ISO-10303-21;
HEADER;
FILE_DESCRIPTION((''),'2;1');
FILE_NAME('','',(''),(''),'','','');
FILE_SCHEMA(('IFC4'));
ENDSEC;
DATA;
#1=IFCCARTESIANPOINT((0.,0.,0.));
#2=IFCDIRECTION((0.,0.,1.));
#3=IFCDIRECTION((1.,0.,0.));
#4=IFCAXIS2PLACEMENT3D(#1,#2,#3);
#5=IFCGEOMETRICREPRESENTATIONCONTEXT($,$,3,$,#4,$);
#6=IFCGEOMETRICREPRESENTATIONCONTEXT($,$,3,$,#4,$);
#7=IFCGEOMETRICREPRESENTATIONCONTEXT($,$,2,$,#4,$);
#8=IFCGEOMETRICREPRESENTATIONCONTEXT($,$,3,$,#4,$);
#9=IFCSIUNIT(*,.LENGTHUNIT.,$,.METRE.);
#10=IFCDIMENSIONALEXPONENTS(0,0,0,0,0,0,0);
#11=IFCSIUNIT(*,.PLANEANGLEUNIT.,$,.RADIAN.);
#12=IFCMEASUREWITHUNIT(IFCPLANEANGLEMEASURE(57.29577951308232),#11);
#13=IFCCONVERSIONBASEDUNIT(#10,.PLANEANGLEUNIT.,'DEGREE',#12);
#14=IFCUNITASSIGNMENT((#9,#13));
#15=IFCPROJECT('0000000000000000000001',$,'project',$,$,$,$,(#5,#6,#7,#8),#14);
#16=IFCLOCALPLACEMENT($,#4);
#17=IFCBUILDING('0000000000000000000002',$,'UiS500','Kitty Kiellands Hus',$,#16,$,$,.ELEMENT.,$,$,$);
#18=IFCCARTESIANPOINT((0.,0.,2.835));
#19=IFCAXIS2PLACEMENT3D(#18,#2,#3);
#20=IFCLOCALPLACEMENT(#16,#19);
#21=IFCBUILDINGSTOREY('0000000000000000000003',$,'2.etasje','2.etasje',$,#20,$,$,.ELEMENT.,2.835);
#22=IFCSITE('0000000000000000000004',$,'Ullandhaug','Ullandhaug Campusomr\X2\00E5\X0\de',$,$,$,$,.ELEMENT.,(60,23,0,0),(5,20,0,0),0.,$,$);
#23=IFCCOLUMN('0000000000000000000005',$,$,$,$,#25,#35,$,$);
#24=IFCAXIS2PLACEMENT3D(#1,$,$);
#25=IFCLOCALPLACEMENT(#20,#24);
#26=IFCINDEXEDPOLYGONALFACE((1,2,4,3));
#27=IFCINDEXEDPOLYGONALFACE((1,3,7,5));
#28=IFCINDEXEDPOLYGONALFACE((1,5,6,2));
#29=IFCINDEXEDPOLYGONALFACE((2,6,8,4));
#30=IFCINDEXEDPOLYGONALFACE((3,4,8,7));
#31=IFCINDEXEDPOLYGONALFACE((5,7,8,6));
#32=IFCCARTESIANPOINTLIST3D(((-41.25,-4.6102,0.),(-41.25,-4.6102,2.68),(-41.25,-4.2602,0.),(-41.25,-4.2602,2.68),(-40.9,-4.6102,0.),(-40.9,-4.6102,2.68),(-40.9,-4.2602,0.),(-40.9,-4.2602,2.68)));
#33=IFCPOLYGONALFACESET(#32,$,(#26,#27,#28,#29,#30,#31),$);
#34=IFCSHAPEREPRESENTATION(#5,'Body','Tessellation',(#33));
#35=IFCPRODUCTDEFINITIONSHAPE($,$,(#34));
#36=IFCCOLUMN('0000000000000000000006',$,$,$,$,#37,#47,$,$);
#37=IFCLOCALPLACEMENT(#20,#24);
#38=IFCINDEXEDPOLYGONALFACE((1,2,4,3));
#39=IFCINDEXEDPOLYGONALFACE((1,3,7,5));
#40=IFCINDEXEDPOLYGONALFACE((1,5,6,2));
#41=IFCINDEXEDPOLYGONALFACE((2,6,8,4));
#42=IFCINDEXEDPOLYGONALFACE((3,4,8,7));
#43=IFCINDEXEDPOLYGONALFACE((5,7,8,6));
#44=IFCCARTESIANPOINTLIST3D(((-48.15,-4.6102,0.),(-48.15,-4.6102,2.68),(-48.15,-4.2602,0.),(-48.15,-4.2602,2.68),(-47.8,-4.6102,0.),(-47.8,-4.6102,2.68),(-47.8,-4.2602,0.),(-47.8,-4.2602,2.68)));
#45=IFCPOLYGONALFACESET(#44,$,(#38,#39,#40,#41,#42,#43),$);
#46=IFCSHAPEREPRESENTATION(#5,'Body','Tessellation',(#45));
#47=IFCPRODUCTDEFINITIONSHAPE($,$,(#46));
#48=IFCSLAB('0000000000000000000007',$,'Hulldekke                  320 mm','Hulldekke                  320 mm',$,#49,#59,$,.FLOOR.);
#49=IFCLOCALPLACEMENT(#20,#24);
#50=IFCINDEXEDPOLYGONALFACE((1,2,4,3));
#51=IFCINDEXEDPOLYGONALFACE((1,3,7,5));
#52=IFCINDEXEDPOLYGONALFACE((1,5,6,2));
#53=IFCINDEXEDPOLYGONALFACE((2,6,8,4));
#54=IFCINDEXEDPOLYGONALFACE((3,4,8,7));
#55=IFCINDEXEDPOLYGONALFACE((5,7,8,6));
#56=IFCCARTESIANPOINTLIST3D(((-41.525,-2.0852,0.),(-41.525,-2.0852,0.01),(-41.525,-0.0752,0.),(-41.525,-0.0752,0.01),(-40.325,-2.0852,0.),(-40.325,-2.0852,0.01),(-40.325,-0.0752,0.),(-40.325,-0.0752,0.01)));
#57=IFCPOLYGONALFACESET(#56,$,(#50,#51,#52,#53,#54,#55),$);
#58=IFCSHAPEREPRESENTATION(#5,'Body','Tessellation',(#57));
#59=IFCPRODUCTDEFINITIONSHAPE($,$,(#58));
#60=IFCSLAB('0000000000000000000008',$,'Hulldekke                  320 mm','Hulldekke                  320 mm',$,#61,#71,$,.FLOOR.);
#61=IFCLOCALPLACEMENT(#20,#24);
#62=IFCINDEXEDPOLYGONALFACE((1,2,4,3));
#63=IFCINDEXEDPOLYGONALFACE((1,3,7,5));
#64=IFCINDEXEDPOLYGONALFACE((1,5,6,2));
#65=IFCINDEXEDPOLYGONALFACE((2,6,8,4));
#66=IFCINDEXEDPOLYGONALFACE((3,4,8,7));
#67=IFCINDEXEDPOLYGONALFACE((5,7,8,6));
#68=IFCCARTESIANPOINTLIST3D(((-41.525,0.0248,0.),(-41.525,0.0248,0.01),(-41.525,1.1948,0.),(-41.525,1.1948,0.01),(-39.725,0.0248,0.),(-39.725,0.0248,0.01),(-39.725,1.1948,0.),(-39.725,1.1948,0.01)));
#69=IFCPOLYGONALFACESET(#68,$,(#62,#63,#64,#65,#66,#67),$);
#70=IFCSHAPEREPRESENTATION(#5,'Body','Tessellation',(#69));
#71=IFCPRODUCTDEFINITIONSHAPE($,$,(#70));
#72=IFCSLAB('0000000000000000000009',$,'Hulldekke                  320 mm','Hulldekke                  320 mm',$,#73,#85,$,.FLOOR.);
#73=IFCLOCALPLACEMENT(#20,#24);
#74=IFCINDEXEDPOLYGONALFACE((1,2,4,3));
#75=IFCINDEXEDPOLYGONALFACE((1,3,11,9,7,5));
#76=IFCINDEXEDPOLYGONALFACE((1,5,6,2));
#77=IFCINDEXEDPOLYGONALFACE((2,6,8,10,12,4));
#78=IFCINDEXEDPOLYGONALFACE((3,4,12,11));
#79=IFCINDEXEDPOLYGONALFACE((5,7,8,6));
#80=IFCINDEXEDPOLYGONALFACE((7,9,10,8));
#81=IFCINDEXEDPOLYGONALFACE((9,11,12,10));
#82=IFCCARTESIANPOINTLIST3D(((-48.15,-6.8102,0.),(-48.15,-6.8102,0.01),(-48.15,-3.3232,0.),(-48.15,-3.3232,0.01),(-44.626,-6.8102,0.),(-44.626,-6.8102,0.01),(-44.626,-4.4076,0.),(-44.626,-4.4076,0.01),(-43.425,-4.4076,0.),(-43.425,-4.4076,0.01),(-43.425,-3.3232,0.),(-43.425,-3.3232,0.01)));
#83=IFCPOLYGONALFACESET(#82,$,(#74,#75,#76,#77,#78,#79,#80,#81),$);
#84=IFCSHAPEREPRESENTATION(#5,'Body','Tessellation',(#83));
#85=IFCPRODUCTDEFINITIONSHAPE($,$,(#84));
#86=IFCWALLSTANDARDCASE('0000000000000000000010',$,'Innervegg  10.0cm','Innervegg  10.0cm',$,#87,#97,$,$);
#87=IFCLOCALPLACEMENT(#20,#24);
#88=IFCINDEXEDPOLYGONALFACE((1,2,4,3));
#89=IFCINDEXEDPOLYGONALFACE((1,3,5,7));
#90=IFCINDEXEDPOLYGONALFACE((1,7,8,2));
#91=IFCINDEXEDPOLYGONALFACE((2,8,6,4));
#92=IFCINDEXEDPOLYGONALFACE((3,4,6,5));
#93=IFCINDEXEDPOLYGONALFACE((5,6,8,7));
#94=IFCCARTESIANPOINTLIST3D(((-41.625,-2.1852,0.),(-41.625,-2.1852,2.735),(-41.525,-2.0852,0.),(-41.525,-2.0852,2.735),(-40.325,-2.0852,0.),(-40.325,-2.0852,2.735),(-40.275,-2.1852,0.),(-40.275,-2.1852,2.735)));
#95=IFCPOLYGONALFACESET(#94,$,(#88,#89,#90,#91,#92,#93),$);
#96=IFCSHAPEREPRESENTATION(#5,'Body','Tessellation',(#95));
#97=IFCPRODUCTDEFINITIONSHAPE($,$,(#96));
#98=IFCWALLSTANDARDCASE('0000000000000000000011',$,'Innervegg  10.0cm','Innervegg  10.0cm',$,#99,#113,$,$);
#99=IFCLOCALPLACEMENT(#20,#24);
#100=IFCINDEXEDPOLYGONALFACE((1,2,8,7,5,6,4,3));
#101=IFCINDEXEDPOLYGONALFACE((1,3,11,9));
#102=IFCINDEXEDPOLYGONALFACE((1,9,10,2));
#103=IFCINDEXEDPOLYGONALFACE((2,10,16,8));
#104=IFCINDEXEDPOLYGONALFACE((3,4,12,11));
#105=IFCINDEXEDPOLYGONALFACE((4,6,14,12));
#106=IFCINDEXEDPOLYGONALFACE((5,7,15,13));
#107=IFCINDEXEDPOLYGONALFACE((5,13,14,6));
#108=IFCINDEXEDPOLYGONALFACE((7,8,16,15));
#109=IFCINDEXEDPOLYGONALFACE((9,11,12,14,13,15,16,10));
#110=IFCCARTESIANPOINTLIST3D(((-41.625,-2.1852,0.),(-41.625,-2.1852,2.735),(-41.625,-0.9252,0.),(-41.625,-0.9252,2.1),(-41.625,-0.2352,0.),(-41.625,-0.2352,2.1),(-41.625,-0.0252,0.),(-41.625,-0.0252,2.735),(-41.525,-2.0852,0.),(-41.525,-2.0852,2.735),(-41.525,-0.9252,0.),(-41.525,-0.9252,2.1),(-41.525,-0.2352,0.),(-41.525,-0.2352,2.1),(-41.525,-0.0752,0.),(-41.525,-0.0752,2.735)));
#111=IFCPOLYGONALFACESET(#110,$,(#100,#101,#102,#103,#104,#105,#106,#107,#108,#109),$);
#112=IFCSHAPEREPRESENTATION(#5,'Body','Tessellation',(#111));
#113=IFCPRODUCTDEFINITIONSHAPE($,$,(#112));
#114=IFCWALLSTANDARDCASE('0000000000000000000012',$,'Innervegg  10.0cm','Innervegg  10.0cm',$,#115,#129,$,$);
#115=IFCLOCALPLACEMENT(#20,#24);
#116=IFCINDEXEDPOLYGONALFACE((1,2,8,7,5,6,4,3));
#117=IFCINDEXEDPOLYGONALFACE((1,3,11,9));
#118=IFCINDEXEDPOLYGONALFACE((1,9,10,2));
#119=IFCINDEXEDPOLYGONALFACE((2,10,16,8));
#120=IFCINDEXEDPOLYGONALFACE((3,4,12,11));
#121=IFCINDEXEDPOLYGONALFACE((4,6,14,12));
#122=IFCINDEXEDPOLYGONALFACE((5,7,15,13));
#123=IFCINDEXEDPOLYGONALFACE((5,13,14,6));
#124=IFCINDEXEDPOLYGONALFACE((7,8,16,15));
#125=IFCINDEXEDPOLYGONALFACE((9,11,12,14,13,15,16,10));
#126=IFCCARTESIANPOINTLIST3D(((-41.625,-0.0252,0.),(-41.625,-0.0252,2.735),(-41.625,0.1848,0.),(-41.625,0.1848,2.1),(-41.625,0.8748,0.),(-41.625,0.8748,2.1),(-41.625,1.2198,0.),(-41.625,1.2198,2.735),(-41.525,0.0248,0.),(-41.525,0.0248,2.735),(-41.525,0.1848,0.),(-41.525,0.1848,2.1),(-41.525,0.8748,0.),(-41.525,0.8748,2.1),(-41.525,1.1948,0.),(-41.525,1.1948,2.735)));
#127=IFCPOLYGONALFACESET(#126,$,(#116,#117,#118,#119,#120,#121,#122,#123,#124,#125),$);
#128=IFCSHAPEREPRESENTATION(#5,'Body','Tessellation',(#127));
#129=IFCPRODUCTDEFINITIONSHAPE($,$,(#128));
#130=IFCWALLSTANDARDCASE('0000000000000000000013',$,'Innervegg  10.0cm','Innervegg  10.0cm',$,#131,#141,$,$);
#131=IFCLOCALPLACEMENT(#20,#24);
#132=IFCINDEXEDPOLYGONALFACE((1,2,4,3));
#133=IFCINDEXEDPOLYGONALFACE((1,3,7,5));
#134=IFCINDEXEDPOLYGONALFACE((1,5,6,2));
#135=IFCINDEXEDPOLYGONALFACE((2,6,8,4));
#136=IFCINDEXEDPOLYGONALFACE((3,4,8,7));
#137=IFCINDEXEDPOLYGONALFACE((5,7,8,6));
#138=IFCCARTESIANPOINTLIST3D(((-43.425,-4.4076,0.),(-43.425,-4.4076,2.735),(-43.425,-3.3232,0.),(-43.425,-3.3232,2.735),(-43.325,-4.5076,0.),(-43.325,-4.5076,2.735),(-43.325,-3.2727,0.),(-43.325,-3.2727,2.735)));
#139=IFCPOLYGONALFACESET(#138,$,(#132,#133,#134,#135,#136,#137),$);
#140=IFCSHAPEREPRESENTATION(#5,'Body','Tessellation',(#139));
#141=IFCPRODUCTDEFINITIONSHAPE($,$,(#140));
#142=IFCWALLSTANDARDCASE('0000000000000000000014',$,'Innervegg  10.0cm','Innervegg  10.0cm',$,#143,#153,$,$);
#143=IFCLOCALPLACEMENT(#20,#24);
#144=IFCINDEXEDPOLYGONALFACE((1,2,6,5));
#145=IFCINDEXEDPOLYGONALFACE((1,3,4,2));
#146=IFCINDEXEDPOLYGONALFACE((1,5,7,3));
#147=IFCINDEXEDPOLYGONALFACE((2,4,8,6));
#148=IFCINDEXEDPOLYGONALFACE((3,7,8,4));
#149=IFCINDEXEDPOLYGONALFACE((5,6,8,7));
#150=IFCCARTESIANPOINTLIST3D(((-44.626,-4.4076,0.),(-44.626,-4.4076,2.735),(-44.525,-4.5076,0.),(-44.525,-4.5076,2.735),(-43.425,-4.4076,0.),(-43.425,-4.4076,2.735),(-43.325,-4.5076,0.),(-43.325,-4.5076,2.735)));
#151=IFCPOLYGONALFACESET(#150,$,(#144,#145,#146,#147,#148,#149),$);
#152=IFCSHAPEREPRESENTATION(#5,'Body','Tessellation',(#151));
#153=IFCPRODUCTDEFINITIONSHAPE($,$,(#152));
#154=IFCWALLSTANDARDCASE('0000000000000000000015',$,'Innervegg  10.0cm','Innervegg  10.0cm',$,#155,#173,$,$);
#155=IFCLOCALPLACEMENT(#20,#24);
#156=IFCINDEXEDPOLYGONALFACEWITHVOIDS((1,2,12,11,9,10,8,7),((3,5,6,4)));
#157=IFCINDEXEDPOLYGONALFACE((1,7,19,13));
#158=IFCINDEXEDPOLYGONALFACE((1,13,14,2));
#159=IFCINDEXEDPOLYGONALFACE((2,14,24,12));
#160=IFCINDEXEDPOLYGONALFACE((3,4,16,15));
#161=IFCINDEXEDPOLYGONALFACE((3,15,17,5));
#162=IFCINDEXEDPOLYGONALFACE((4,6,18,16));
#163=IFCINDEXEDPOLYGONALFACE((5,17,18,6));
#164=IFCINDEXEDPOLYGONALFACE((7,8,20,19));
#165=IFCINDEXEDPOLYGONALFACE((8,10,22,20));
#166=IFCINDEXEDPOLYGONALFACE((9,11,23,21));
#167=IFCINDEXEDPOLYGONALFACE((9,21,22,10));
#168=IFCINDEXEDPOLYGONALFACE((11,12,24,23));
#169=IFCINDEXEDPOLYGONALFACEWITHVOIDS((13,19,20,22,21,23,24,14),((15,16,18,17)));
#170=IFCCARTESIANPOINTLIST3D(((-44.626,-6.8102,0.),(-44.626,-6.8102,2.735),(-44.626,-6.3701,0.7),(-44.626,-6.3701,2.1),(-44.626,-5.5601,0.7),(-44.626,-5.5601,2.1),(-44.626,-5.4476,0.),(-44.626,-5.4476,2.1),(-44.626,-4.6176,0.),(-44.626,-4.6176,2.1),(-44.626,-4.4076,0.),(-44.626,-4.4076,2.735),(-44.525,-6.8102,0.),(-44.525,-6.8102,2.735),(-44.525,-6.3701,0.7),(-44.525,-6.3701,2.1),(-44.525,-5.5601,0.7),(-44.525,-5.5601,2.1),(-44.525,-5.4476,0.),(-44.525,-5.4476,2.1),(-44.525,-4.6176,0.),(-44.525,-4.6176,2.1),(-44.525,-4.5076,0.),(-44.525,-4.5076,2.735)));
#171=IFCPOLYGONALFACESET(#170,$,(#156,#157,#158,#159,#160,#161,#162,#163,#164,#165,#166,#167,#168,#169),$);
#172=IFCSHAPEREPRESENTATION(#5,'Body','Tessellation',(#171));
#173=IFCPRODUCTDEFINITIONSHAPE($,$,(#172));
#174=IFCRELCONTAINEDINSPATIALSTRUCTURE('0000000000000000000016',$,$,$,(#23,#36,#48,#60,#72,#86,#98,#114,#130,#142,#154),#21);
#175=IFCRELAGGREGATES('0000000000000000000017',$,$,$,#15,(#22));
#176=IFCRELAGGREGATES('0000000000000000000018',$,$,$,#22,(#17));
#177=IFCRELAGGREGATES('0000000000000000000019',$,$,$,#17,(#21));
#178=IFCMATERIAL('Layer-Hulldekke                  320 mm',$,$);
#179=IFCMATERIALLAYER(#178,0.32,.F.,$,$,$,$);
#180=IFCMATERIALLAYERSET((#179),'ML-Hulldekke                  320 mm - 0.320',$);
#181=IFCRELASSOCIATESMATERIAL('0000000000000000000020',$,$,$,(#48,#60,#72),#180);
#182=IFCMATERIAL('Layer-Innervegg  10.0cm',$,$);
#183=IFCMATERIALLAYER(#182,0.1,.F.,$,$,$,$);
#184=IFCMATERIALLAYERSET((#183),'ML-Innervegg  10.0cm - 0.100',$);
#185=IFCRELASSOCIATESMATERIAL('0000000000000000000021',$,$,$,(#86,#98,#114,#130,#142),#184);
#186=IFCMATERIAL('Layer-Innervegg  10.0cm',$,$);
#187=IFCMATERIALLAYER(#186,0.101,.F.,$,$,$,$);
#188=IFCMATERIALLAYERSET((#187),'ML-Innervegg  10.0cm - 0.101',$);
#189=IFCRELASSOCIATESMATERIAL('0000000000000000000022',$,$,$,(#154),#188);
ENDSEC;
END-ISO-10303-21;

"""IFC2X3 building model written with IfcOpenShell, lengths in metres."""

from ifc_helpers import new_model, entity, si_unit, converted_unit, frame, origin_with_axes, origin_2d_with_axis, place, context, project, spatial, polyline, rectangle, outline, extrude, material, layer, layer_set, layer_usage, element, save


model = new_model("IFC2X3")

# Units and contexts
context_of_model_1 = context(None, 3, world=origin_with_axes())
context_of_model_2 = context(None, 3, world=origin_with_axes())
context_of_model_3 = context(None, 2, world=origin_with_axes())
context_of_model_4 = context(None, 3, world=origin_with_axes())
ifc_project = project(units=[si_unit("LENGTHUNIT", "METRE"), converted_unit("PLANEANGLEUNIT", "DEGREE", entity("IfcPlaneAngleMeasure", 57.29577951308232), si_unit("PLANEANGLEUNIT", "RADIAN"), dimensions=[0, 0, 0, 0, 0, 0, 0])], contexts=[context_of_model_1, context_of_model_2, context_of_model_3, context_of_model_4])

# Site, building, storey
site = spatial("IfcSite", under=ifc_project, Name="Ullandhaug", Description="Ullandhaug Campusområde", CompositionType="ELEMENT", RefLatitude=(60, 23, 0, 0), RefLongitude=(5, 20, 0, 0), RefElevation=0.0)
building_placement = place(None, origin_with_axes())
building = spatial("IfcBuilding", under=site, at=building_placement, Name="UiS500", Description="Kitty Kiellands Hus", CompositionType="ELEMENT")
storey_placement = place(building_placement, frame((0.0, 0.0, 2.835), z_axis=(0.0, 0.0, 1.0), x_axis=(1.0, 0.0, 0.0)))
storey = spatial("IfcBuildingStorey", under=building, at=storey_placement, Name="2.etasje", Description="2.etasje", CompositionType="ELEMENT", Elevation=2.835)

# Columns
for number, where, z_axis, x_axis in (
    (1, (-41.075, -4.4352, 0.0), (0.0, 0.0, 1.0), (1.0, 0.0, 0.0)),
    (2, (-47.975, -4.4352, 0.0), (0.0, 0.0, 1.0), (1.0, 0.0, 0.0)),
):
    element("IfcColumn", number, at=place(storey_placement, frame(where, z_axis=z_axis, x_axis=x_axis)), inside=storey, context=context_of_model_1, shape_type="SweptSolid", body=[
        extrude(rectangle(XDim=0.35, YDim=0.35, at=origin_2d_with_axis()), origin_with_axes(), (0.0, 0.0, 1.0), 2.68),
    ])

# Slabs
ifc_material_1 = material(Name="Layer-Hulldekke                  320 mm")
ifc_layer_1 = layer(ifc_material_1, 0.32, ventilated=False)
ifc_layer_set_1 = layer_set([ifc_layer_1], Name="ML-Hulldekke                  320 mm - 0.320")
ifc_layer_usage_1 = layer_usage(ifc_layer_set_1, "AXIS2", "POSITIVE", 0.0)
slab_1_placement = place(storey_placement, frame((-41.525, -2.0852, 0.0), z_axis=(0.0, 0.0, 1.0), x_axis=(1.0, 0.0, 0.0)))
element("IfcSlab", 3, at=slab_1_placement, inside=storey, material=ifc_layer_usage_1, Name="Hulldekke                  320 mm", Description="Hulldekke                  320 mm", PredefinedType="FLOOR", context=context_of_model_1, shape_type="SweptSolid", body=[
    extrude(outline(polyline([(0.0, 0.0), (1.2, 0.0), (1.2, 2.01), (0.0, 2.01), (0.0, 0.0)])), origin_with_axes(), (0.0, 0.0, 1.0), 0.01),
])
slab_2_placement = place(storey_placement, frame((-41.525, 0.0248, 0.0), z_axis=(0.0, 0.0, 1.0), x_axis=(1.0, 0.0, 0.0)))
element("IfcSlab", 4, at=slab_2_placement, inside=storey, material=ifc_layer_usage_1, Name="Hulldekke                  320 mm", Description="Hulldekke                  320 mm", PredefinedType="FLOOR", context=context_of_model_1, shape_type="SweptSolid", body=[
    extrude(outline(polyline([(0.0, 0.0), (1.8, 0.0), (1.8, 1.17), (0.0, 1.17), (0.0, 0.0)])), origin_with_axes(), (0.0, 0.0, 1.0), 0.01),
])
slab_3_placement = place(storey_placement, frame((-43.425, -3.3232, 0.0), z_axis=(0.0, 0.0, 1.0), x_axis=(1.0, 0.0, 0.0)))
element("IfcSlab", 5, at=slab_3_placement, inside=storey, material=ifc_layer_usage_1, Name="Hulldekke                  320 mm", Description="Hulldekke                  320 mm", PredefinedType="FLOOR", context=context_of_model_1, shape_type="SweptSolid", body=[
    extrude(outline(polyline([(0.0, 0.0), (4.725, 0.0), (4.725, 3.487), (1.201, 3.487), (1.201, 1.0843), (0.0, 1.0843), (0.0, 0.0)])), frame((0.0, 0.0, 0.0), z_axis=(0.0, 0.0, 1.0), x_axis=(-1.0, 0.0, 0.0)), (0.0, 0.0, 1.0), 0.01),
])

# Wall
ifc_material_2 = material(Name="Layer-Innervegg  10.0cm")
ifc_layer_2 = layer(ifc_material_2, 0.1, ventilated=False)
ifc_layer_set_2 = layer_set([ifc_layer_2], Name="ML-Innervegg  10.0cm - 0.100")
ifc_layer_usage_2 = layer_usage(ifc_layer_set_2, "AXIS2", "POSITIVE", 0.0)
wall_1_placement = place(storey_placement, frame((-40.325, -2.0852, 0.0), z_axis=(0.0, 0.0, 1.0), x_axis=(-1.0, 0.0, 0.0)))
element("IfcWallStandardCase", 6, at=wall_1_placement, inside=storey, material=ifc_layer_usage_2, Name="Innervegg  10.0cm", Description="Innervegg  10.0cm", context=context_of_model_1, shape_type="SweptSolid", body=[
    extrude(outline(polyline([(0.0, 0.0), (1.2, 0.0), (1.3, 0.1), (-0.05, 0.1), (0.0, 0.0)])), frame((0.0, 0.0, 0.0), z_axis=(0.0, 0.0, 1.0), x_axis=(1.0, 0.0, 0.0)), (0.0, 0.0, 1.0), 2.735),
])

# Walls, openings
wall_2_placement = place(storey_placement, frame((-41.525, -2.0852, 0.0), z_axis=(0.0, 0.0, 1.0), x_axis=(0.0, 1.0, 0.0)))
wall_2 = element("IfcWallStandardCase", 7, at=wall_2_placement, inside=storey, material=ifc_layer_usage_2, Name="Innervegg  10.0cm", Description="Innervegg  10.0cm", context=context_of_model_1, shape_type="SweptSolid", body=[
    extrude(outline(polyline([(0.0, 0.0), (2.01, 0.0), (2.06, 0.1), (-0.1, 0.1), (0.0, 0.0)])), frame((0.0, 0.0, 0.0), z_axis=(0.0, 0.0, 1.0), x_axis=(1.0, 0.0, 0.0)), (0.0, 0.0, 1.0), 2.735),
])
opening_1_placement = place(wall_2_placement, frame((1.16, 0.1, 0.0), z_axis=(0.0, 0.0, 1.0), x_axis=(1.0, 0.0, 0.0)))
element("IfcOpeningElement", 8, at=opening_1_placement, cuts=wall_2, context=context_of_model_1, shape_type="SweptSolid", body=[
    extrude(outline(polyline([(0.0, 0.0), (2.1, 0.0), (2.1, 0.69), (0.0, 0.69), (0.0, 0.0)])), frame((0.0, 0.0, 0.0), z_axis=(0.0, 1.0, 0.0), x_axis=(0.0, 0.0, 1.0)), (0.0, 0.0, -1.0), 0.1),
])
wall_3_placement = place(storey_placement, frame((-41.525, 0.0248, 0.0), z_axis=(0.0, 0.0, 1.0), x_axis=(0.0, 1.0, 0.0)))
wall_3 = element("IfcWallStandardCase", 9, at=wall_3_placement, inside=storey, material=ifc_layer_usage_2, Name="Innervegg  10.0cm", Description="Innervegg  10.0cm", context=context_of_model_1, shape_type="SweptSolid", body=[
    extrude(outline(polyline([(0.0, 0.0), (1.17, 0.0), (1.195, 0.1), (-0.05, 0.1), (0.0, 0.0)])), frame((0.0, 0.0, 0.0), z_axis=(0.0, 0.0, 1.0), x_axis=(1.0, 0.0, 0.0)), (0.0, 0.0, 1.0), 2.735),
])
opening_2_placement = place(wall_3_placement, frame((0.16, 0.1, 0.0), z_axis=(0.0, 0.0, 1.0), x_axis=(1.0, 0.0, 0.0)))
element("IfcOpeningElement", 10, at=opening_2_placement, cuts=wall_3, context=context_of_model_1, shape_type="SweptSolid", body=[
    extrude(outline(polyline([(0.0, 0.0), (2.1, 0.0), (2.1, 0.69), (0.0, 0.69), (0.0, 0.0)])), frame((0.0, 0.0, 0.0), z_axis=(0.0, 1.0, 0.0), x_axis=(0.0, 0.0, 1.0)), (0.0, 0.0, -1.0), 0.1),
])

# Walls
wall_4_placement = place(storey_placement, frame((-43.425, -3.3232, 0.0), z_axis=(0.0, 0.0, 1.0), x_axis=(0.0, -1.0, 0.0)))
element("IfcWallStandardCase", 11, at=wall_4_placement, inside=storey, material=ifc_layer_usage_2, Name="Innervegg  10.0cm", Description="Innervegg  10.0cm", context=context_of_model_1, shape_type="SweptSolid", body=[
    extrude(outline(polyline([(0.0, 0.0), (1.0843, 0.0), (1.1843, 0.1), (-0.0505, 0.1), (0.0, 0.0)])), frame((0.0, 0.0, 0.0), z_axis=(0.0, 0.0, 1.0), x_axis=(1.0, 0.0, 0.0)), (0.0, 0.0, 1.0), 2.735),
])
wall_5_placement = place(storey_placement, frame((-43.425, -4.4076, 0.0), z_axis=(0.0, 0.0, 1.0), x_axis=(-1.0, 0.0, 0.0)))
element("IfcWallStandardCase", 12, at=wall_5_placement, inside=storey, material=ifc_layer_usage_2, Name="Innervegg  10.0cm", Description="Innervegg  10.0cm", context=context_of_model_1, shape_type="SweptSolid", body=[
    extrude(outline(polyline([(0.0, 0.0), (1.201, 0.0), (1.1, 0.1), (-0.1, 0.1), (0.0, 0.0)])), frame((0.0, 0.0, 0.0), z_axis=(0.0, 0.0, 1.0), x_axis=(1.0, 0.0, 0.0)), (0.0, 0.0, 1.0), 2.735),
])

# Wall, openings
ifc_material_3 = material(Name="Layer-Innervegg  10.0cm")
ifc_layer_3 = layer(ifc_material_3, 0.101, ventilated=False)
ifc_layer_set_3 = layer_set([ifc_layer_3], Name="ML-Innervegg  10.0cm - 0.101")
ifc_layer_usage_3 = layer_usage(ifc_layer_set_3, "AXIS2", "POSITIVE", 0.0)
wall_6_placement = place(storey_placement, frame((-44.626, -4.4076, 0.0), z_axis=(0.0, 0.0, 1.0), x_axis=(0.0, -1.0, 0.0)))
wall_6 = element("IfcWallStandardCase", 13, at=wall_6_placement, inside=storey, material=ifc_layer_usage_3, Name="Innervegg  10.0cm", Description="Innervegg  10.0cm", context=context_of_model_1, shape_type="SweptSolid", body=[
    extrude(outline(polyline([(0.0, 0.0), (2.4027, 0.0), (2.4027, 0.101), (0.1, 0.101), (0.0, 0.0)])), frame((0.0, 0.0, 0.0), z_axis=(0.0, 0.0, 1.0), x_axis=(1.0, 0.0, 0.0)), (0.0, 0.0, 1.0), 2.735),
])
opening_3_placement = place(wall_6_placement, frame((0.21, 0.101, 0.0), z_axis=(0.0, 0.0, 1.0), x_axis=(1.0, 0.0, 0.0)))
element("IfcOpeningElement", 14, at=opening_3_placement, cuts=wall_6, context=context_of_model_1, shape_type="SweptSolid", body=[
    extrude(outline(polyline([(0.0, 0.0), (2.1, 0.0), (2.1, 0.83), (0.0, 0.83), (0.0, 0.0)])), frame((0.0, 0.0, 0.0), z_axis=(0.0, 1.0, 0.0), x_axis=(0.0, 0.0, 1.0)), (0.0, 0.0, -1.0), 0.101),
])
opening_4_placement = place(wall_6_placement, frame((1.1525, 0.101, 0.7), z_axis=(0.0, 0.0, 1.0), x_axis=(1.0, 0.0, 0.0)))
element("IfcOpeningElement", 15, at=opening_4_placement, cuts=wall_6, context=context_of_model_1, shape_type="SweptSolid", body=[
    extrude(outline(polyline([(0.0, 0.0), (1.4, 0.0), (1.4, 0.81), (0.0, 0.81), (0.0, 0.0)])), frame((0.0, 0.0, 0.0), z_axis=(0.0, 1.0, 0.0), x_axis=(0.0, 0.0, 1.0)), (0.0, 0.0, -1.0), 0.101),
])

save(model, "model.ifc")
